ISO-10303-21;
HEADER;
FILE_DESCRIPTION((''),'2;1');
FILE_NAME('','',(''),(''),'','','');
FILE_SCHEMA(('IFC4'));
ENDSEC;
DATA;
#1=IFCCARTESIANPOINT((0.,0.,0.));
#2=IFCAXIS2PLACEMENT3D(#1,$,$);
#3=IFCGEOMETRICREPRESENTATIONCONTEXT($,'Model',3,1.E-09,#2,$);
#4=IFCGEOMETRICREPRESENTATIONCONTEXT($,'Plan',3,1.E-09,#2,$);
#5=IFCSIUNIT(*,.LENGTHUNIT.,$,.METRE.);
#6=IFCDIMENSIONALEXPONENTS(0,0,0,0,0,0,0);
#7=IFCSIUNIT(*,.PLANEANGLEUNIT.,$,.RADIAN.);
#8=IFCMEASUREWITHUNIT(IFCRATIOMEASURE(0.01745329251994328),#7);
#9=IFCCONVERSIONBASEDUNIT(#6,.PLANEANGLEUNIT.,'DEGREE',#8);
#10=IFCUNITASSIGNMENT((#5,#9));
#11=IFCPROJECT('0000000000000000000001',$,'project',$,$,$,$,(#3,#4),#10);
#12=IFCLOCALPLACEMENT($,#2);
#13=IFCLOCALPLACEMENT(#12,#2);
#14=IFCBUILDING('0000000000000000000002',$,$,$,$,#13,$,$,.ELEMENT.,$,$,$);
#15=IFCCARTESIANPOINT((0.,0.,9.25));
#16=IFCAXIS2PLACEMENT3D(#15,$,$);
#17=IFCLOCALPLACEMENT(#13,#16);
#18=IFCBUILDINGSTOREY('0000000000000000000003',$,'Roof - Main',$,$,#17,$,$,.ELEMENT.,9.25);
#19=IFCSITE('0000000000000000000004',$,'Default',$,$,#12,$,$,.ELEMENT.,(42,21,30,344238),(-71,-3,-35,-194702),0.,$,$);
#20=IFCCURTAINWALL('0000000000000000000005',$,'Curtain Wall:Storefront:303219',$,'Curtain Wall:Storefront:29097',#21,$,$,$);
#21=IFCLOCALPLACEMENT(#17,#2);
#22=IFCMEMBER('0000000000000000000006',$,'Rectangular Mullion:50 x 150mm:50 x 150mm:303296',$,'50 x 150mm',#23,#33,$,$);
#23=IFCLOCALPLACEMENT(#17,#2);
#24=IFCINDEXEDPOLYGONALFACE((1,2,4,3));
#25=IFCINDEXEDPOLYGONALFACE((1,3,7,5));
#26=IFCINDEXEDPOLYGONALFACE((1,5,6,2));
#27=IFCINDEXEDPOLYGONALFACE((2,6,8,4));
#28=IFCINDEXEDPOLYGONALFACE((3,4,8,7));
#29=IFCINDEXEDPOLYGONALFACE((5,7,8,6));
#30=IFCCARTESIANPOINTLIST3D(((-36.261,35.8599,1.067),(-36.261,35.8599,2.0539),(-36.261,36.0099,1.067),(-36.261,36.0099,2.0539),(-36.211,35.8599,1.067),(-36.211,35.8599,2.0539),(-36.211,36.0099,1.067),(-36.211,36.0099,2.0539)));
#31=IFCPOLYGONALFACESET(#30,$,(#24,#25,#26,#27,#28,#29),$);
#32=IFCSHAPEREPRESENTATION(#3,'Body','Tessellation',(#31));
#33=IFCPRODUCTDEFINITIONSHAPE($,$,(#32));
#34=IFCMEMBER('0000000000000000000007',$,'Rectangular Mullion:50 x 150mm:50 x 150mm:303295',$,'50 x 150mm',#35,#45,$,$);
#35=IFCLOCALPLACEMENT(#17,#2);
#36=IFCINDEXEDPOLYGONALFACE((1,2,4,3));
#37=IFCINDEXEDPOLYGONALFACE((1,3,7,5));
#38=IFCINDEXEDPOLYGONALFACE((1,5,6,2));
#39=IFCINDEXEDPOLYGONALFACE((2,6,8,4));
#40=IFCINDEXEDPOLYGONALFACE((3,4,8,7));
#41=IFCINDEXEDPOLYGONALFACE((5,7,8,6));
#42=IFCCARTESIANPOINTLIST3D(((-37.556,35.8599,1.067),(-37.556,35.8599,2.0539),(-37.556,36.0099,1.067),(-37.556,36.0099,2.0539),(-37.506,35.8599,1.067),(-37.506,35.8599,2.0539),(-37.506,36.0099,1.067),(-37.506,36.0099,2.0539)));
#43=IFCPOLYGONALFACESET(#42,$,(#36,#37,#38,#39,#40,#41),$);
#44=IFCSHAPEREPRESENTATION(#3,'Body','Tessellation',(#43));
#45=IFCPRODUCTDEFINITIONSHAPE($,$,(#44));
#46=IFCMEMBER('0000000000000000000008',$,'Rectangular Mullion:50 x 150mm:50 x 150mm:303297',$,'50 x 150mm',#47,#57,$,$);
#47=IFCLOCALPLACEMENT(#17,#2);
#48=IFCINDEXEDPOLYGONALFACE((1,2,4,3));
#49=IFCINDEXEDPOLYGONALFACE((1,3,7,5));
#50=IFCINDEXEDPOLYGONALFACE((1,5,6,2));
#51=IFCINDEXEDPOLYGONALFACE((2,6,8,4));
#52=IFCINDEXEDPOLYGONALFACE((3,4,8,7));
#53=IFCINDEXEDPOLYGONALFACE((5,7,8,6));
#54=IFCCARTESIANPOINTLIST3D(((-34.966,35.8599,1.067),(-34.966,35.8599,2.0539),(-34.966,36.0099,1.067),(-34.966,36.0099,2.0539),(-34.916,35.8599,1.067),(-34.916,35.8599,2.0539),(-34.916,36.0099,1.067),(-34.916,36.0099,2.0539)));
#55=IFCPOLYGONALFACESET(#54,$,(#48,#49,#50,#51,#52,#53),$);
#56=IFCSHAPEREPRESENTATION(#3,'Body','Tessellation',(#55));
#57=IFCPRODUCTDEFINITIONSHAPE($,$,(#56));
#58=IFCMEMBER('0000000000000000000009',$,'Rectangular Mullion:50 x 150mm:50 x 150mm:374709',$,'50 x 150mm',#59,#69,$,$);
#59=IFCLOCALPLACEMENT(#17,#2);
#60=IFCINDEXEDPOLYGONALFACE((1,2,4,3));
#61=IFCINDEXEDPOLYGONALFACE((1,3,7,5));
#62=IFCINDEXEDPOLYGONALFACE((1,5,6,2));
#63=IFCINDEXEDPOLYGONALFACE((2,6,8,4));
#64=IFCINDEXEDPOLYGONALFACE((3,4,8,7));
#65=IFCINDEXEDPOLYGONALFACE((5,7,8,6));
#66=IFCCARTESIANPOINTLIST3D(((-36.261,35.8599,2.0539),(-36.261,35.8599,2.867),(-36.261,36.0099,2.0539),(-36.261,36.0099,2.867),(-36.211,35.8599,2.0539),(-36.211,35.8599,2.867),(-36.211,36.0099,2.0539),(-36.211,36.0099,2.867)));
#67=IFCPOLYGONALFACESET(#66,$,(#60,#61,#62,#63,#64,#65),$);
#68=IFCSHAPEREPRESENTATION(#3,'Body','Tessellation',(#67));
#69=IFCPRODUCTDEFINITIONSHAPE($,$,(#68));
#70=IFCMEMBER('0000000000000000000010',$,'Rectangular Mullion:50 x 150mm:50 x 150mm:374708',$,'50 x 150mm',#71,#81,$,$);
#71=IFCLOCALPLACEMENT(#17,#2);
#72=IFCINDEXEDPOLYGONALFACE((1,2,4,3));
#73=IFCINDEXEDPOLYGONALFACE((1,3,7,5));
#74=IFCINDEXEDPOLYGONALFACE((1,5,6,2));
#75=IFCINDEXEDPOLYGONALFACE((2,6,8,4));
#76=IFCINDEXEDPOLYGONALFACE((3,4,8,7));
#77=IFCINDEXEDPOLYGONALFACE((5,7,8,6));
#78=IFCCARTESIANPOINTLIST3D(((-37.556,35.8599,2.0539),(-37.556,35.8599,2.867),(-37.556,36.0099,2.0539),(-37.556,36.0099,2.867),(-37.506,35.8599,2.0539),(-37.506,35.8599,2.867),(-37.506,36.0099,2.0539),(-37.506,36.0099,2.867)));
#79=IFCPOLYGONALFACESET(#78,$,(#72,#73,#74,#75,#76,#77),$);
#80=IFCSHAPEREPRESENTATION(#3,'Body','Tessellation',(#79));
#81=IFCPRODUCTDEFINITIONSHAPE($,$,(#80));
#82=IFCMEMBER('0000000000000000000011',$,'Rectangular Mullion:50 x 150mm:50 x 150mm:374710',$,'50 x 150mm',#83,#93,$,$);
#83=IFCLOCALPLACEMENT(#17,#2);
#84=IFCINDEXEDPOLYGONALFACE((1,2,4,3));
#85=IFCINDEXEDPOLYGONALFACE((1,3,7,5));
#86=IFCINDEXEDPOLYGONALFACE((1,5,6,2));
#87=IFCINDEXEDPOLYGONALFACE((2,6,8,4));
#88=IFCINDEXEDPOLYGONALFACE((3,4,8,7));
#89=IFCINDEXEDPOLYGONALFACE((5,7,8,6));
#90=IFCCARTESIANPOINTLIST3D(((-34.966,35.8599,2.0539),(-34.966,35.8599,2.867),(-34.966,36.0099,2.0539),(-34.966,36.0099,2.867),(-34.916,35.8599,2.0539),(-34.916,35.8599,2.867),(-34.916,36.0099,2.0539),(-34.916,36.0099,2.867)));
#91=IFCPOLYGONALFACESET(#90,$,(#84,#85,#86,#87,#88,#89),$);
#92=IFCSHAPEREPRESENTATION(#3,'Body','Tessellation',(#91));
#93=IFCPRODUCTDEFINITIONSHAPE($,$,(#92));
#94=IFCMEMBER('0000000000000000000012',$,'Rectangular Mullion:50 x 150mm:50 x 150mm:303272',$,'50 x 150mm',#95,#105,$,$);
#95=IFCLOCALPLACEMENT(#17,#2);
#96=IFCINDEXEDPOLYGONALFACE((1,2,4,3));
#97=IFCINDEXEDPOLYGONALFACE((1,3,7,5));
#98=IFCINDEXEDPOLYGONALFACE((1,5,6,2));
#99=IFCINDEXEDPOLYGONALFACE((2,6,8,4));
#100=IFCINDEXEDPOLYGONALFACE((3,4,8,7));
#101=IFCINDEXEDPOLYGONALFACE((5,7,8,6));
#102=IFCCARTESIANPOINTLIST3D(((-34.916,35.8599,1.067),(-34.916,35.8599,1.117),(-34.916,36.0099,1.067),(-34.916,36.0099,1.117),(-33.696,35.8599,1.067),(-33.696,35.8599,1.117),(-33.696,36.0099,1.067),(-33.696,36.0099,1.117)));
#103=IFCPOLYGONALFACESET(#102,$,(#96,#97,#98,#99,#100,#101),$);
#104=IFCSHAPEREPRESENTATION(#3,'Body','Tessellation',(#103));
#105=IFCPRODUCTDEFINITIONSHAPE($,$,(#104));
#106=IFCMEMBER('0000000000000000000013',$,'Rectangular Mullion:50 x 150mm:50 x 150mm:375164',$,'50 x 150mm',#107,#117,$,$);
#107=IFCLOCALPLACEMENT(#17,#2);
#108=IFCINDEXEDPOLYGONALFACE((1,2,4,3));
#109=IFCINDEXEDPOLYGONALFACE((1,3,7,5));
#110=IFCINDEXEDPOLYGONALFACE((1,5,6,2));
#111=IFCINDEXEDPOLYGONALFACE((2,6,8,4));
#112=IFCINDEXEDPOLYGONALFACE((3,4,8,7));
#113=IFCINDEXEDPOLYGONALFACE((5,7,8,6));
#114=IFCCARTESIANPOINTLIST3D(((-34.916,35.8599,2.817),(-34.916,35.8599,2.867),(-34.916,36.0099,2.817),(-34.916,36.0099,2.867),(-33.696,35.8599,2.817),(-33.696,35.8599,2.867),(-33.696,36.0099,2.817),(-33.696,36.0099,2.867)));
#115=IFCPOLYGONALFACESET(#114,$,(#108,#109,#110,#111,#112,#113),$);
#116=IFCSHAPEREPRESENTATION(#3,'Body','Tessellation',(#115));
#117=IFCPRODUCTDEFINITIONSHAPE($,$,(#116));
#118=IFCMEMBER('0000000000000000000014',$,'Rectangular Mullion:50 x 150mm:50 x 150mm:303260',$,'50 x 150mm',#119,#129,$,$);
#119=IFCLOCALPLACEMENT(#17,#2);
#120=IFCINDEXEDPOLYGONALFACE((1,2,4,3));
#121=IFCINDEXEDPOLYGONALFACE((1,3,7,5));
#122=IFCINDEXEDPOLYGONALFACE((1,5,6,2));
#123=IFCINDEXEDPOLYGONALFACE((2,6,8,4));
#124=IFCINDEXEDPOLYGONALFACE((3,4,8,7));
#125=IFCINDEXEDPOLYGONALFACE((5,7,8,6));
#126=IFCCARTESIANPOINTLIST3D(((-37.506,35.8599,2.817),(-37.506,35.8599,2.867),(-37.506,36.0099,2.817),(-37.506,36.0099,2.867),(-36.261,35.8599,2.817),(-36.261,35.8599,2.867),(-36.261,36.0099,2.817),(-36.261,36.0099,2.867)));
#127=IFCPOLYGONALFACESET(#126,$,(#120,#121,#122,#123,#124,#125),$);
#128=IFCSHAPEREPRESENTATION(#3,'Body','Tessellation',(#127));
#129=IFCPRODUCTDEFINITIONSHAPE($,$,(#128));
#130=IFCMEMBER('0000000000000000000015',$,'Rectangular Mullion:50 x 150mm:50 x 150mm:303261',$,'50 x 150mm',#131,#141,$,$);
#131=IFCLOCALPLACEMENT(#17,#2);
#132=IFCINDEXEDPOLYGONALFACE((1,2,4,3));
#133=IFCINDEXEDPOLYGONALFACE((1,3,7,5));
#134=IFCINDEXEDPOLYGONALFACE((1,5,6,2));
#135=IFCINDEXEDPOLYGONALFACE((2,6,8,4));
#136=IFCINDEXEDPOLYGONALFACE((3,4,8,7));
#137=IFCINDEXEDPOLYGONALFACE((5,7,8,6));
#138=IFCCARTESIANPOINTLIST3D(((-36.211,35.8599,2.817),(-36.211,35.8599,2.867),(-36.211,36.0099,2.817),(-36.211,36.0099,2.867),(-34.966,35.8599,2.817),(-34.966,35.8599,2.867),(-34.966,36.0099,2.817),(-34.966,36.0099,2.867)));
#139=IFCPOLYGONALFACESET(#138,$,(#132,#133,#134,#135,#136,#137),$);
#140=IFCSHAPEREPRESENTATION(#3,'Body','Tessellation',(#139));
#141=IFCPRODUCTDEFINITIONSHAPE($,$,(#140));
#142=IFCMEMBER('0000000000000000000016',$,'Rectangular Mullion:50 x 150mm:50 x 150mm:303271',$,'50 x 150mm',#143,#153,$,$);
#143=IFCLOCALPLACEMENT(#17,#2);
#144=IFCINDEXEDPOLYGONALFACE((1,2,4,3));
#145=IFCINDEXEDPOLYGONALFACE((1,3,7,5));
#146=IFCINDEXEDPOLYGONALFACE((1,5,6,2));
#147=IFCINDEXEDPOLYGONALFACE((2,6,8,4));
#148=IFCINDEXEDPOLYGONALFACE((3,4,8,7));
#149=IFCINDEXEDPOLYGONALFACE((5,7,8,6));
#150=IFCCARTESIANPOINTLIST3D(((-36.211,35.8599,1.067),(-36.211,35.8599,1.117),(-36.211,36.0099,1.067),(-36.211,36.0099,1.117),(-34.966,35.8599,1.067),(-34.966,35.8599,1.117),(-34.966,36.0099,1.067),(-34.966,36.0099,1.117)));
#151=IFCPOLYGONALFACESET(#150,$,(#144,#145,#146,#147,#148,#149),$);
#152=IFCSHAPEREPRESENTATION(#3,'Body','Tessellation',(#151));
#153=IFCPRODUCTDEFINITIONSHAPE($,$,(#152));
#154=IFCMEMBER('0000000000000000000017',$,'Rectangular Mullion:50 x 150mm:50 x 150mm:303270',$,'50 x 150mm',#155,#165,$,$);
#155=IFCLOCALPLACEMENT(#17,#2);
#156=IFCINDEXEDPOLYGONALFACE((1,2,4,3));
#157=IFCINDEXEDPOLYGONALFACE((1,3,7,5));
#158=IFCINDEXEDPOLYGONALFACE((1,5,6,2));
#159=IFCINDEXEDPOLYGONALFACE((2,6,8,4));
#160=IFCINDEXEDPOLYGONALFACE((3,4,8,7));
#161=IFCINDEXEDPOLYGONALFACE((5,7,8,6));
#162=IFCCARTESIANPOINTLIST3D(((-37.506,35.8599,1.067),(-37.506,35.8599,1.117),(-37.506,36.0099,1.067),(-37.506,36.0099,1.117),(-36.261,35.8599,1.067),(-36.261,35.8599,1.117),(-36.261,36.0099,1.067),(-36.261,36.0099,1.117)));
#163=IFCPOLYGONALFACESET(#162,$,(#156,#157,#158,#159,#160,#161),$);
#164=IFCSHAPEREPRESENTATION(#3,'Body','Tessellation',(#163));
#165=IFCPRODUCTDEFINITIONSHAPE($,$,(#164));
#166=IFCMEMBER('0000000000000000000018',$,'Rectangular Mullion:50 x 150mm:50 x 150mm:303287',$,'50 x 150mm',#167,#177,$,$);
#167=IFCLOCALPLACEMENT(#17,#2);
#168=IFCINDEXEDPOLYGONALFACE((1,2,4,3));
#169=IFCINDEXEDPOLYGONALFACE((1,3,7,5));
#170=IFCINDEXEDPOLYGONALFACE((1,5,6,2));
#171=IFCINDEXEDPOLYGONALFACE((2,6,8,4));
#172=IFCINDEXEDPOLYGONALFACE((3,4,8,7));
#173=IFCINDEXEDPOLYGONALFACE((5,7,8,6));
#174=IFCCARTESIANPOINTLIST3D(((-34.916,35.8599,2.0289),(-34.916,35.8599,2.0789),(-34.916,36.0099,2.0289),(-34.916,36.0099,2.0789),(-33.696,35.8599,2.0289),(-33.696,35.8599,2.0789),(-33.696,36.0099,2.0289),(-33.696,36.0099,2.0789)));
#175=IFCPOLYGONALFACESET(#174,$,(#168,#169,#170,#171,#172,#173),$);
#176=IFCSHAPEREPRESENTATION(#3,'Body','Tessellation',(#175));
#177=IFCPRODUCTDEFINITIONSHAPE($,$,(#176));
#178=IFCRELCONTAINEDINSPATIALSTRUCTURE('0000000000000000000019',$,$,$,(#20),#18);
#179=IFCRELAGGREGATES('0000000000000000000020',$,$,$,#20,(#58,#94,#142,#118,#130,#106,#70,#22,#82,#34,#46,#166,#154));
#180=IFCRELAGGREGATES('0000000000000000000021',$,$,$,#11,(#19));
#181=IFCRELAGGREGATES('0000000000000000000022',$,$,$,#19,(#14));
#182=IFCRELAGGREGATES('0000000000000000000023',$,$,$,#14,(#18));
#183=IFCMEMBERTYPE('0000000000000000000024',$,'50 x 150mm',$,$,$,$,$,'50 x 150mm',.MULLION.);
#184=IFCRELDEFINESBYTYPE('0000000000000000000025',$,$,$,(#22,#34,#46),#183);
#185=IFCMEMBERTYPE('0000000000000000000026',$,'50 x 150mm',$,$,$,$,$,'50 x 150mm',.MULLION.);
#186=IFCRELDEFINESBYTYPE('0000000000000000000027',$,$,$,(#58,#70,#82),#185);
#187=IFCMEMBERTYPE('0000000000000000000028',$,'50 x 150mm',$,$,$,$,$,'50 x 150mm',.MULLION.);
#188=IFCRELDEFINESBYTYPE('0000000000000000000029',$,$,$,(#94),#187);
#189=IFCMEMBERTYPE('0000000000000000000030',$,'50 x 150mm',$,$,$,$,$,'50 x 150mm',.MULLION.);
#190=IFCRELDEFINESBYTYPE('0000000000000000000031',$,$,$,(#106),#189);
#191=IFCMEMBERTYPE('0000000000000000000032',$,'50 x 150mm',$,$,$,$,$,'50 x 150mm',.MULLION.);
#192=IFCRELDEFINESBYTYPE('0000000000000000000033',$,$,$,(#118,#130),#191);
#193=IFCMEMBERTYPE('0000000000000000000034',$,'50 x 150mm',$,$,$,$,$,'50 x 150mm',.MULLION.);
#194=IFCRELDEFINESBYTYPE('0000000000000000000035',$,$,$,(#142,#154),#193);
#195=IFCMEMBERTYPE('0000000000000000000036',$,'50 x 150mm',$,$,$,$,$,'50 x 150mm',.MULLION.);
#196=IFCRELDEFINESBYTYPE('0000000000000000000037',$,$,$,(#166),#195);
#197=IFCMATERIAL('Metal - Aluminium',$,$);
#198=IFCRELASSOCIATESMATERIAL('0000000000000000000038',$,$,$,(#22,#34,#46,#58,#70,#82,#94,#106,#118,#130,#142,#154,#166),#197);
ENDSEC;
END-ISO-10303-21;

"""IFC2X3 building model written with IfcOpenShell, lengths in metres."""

from ifc_helpers import new_model, entity, si_unit, converted_unit, frame, origin, origin_2d_with_axis, place, context, project, spatial, rectangle, extrude, source, transform, mapped, material, type_object, type_shapes, element, aggregate, save


model = new_model("IFC2X3")

# Units and contexts
model_context = context("Model", 3, precision=1e-09, world=origin())
plan_context = context("Plan", 3, precision=1e-09, world=origin())
ifc_project = project(units=[si_unit("LENGTHUNIT", "METRE"), converted_unit("PLANEANGLEUNIT", "DEGREE", entity("IfcRatioMeasure", 0.01745329251994328), si_unit("PLANEANGLEUNIT", "RADIAN"), dimensions=[0, 0, 0, 0, 0, 0, 0])], contexts=[model_context, plan_context])

# Site, building, storey
site_placement = place(None, origin())
site = spatial("IfcSite", under=ifc_project, at=site_placement, Name="Default", CompositionType="ELEMENT", RefLatitude=(42, 21, 30, 344238), RefLongitude=(-71, -3, -35, -194702), RefElevation=0.0)
building_placement = place(site_placement, origin())
building = spatial("IfcBuilding", under=site, at=building_placement, CompositionType="ELEMENT")
storey_placement = place(building_placement, frame((0.0, 0.0, 9.25)))
storey = spatial("IfcBuildingStorey", under=building, at=storey_placement, Name="Roof - Main", CompositionType="ELEMENT", Elevation=9.25)

# Curtain wall, members
curtain_wall_placement = place(storey_placement, origin())
curtain_wall = element("IfcCurtainWall", 1, at=curtain_wall_placement, inside=storey, Name="Curtain Wall:Storefront:303219", ObjectType="Curtain Wall:Storefront:29097")
ifc_material_1 = material(Name="Metal - Aluminium")
member_type_1 = type_object("IfcMemberType", Name="50 x 150mm", ElementType="50 x 150mm", PredefinedType="MULLION")
shared_shape_1 = source(origin(), model_context, "Body", "SweptSolid", [
    extrude(rectangle(XDim=0.05, YDim=0.15, at=origin_2d_with_axis()), frame((0.0, 0.0, -0.9869), z_axis=(0.0, 0.0, 1.0), x_axis=(-1.0, 0.0, 0.0)), (0.0, 0.0, 1.0), 0.9869),
])
type_shapes(member_type_1, [shared_shape_1])
member_1_placement = place(storey_placement, frame((-36.236, 35.9349, 1.067), z_axis=(0.0, 0.0, -1.0), x_axis=(1.0, 0.0, 0.0)))
member_1 = element("IfcMember", 2, at=member_1_placement, type_object=member_type_1, material=ifc_material_1, Name="Rectangular Mullion:50 x 150mm:50 x 150mm:303296", ObjectType="50 x 150mm", context=model_context, shape_type="MappedRepresentation", body=[
    mapped(shared_shape_1, transform((0.0, 0.0, 0.0), scale=1.0)),
])
member_2_placement = place(storey_placement, frame((-37.531, 35.9349, 1.067), z_axis=(0.0, 0.0, -1.0), x_axis=(1.0, 0.0, 0.0)))
member_2 = element("IfcMember", 3, at=member_2_placement, type_object=member_type_1, material=ifc_material_1, Name="Rectangular Mullion:50 x 150mm:50 x 150mm:303295", ObjectType="50 x 150mm", context=model_context, shape_type="MappedRepresentation", body=[
    mapped(shared_shape_1, transform((0.0, 0.0, 0.0), scale=1.0)),
])
member_3_placement = place(storey_placement, frame((-34.941, 35.9349, 1.067), z_axis=(0.0, 0.0, -1.0), x_axis=(1.0, 0.0, 0.0)))
member_3 = element("IfcMember", 4, at=member_3_placement, type_object=member_type_1, material=ifc_material_1, Name="Rectangular Mullion:50 x 150mm:50 x 150mm:303297", ObjectType="50 x 150mm", context=model_context, shape_type="MappedRepresentation", body=[
    mapped(shared_shape_1, transform((0.0, 0.0, 0.0), scale=1.0)),
])
member_type_2 = type_object("IfcMemberType", Name="50 x 150mm", ElementType="50 x 150mm", PredefinedType="MULLION")
shared_shape_2 = source(origin(), model_context, "Body", "SweptSolid", [
    extrude(rectangle(XDim=0.05, YDim=0.15, at=origin_2d_with_axis()), frame((0.0, 0.0, -0.8131), z_axis=(0.0, 0.0, 1.0), x_axis=(-1.0, 0.0, 0.0)), (0.0, 0.0, 1.0), 0.8131),
])
type_shapes(member_type_2, [shared_shape_2])
member_4_placement = place(storey_placement, frame((-36.236, 35.9349, 2.0539), z_axis=(0.0, 0.0, -1.0), x_axis=(1.0, 0.0, 0.0)))
member_4 = element("IfcMember", 5, at=member_4_placement, type_object=member_type_2, material=ifc_material_1, Name="Rectangular Mullion:50 x 150mm:50 x 150mm:374709", ObjectType="50 x 150mm", context=model_context, shape_type="MappedRepresentation", body=[
    mapped(shared_shape_2, transform((0.0, 0.0, 0.0), scale=1.0)),
])
member_5_placement = place(storey_placement, frame((-37.531, 35.9349, 2.0539), z_axis=(0.0, 0.0, -1.0), x_axis=(1.0, 0.0, 0.0)))
member_5 = element("IfcMember", 6, at=member_5_placement, type_object=member_type_2, material=ifc_material_1, Name="Rectangular Mullion:50 x 150mm:50 x 150mm:374708", ObjectType="50 x 150mm", context=model_context, shape_type="MappedRepresentation", body=[
    mapped(shared_shape_2, transform((0.0, 0.0, 0.0), scale=1.0)),
])
member_6_placement = place(storey_placement, frame((-34.941, 35.9349, 2.0539), z_axis=(0.0, 0.0, -1.0), x_axis=(1.0, 0.0, 0.0)))
member_6 = element("IfcMember", 7, at=member_6_placement, type_object=member_type_2, material=ifc_material_1, Name="Rectangular Mullion:50 x 150mm:50 x 150mm:374710", ObjectType="50 x 150mm", context=model_context, shape_type="MappedRepresentation", body=[
    mapped(shared_shape_2, transform((0.0, 0.0, 0.0), scale=1.0)),
])
member_type_3 = type_object("IfcMemberType", Name="50 x 150mm", ElementType="50 x 150mm", PredefinedType="MULLION")
shared_shape_3 = source(origin(), model_context, "Body", "SweptSolid", [
    extrude(rectangle(XDim=0.05, YDim=0.15, at=origin_2d_with_axis()), frame((-0.025, 0.0, -1.22), z_axis=(0.0, 0.0, 1.0), x_axis=(-1.0, 0.0, 0.0)), (0.0, 0.0, 1.0), 1.22),
])
type_shapes(member_type_3, [shared_shape_3])
member_7_placement = place(storey_placement, frame((-34.916, 35.9349, 1.067), z_axis=(-1.0, 0.0, 0.0), x_axis=(0.0, 0.0, -1.0)))
member_7 = element("IfcMember", 8, at=member_7_placement, type_object=member_type_3, material=ifc_material_1, Name="Rectangular Mullion:50 x 150mm:50 x 150mm:303272", ObjectType="50 x 150mm", context=model_context, shape_type="MappedRepresentation", body=[
    mapped(shared_shape_3, transform((0.0, 0.0, 0.0), scale=1.0)),
])
member_type_4 = type_object("IfcMemberType", Name="50 x 150mm", ElementType="50 x 150mm", PredefinedType="MULLION")
type_shapes(member_type_4, [shared_shape_3])
member_8_placement = place(storey_placement, frame((-33.696, 35.9349, 2.867), z_axis=(1.0, 0.0, 0.0), x_axis=(0.0, 0.0, 1.0)))
member_8 = element("IfcMember", 9, at=member_8_placement, type_object=member_type_4, material=ifc_material_1, Name="Rectangular Mullion:50 x 150mm:50 x 150mm:375164", ObjectType="50 x 150mm", context=model_context, shape_type="MappedRepresentation", body=[
    mapped(shared_shape_3, transform((0.0, 0.0, 0.0), scale=1.0)),
])
member_type_5 = type_object("IfcMemberType", Name="50 x 150mm", ElementType="50 x 150mm", PredefinedType="MULLION")
shared_shape_4 = source(origin(), model_context, "Body", "SweptSolid", [
    extrude(rectangle(XDim=0.05, YDim=0.15, at=origin_2d_with_axis()), frame((-0.025, 0.0, -1.245), z_axis=(0.0, 0.0, 1.0), x_axis=(-1.0, 0.0, 0.0)), (0.0, 0.0, 1.0), 1.245),
])
type_shapes(member_type_5, [shared_shape_4])
member_9_placement = place(storey_placement, frame((-36.261, 35.9349, 2.867), z_axis=(1.0, 0.0, 0.0), x_axis=(0.0, 0.0, 1.0)))
member_9 = element("IfcMember", 10, at=member_9_placement, type_object=member_type_5, material=ifc_material_1, Name="Rectangular Mullion:50 x 150mm:50 x 150mm:303260", ObjectType="50 x 150mm", context=model_context, shape_type="MappedRepresentation", body=[
    mapped(shared_shape_4, transform((0.0, 0.0, 0.0), scale=1.0)),
])
member_10_placement = place(storey_placement, frame((-34.966, 35.9349, 2.867), z_axis=(1.0, 0.0, 0.0), x_axis=(0.0, 0.0, 1.0)))
member_10 = element("IfcMember", 11, at=member_10_placement, type_object=member_type_5, material=ifc_material_1, Name="Rectangular Mullion:50 x 150mm:50 x 150mm:303261", ObjectType="50 x 150mm", context=model_context, shape_type="MappedRepresentation", body=[
    mapped(shared_shape_4, transform((0.0, 0.0, 0.0), scale=1.0)),
])
member_type_6 = type_object("IfcMemberType", Name="50 x 150mm", ElementType="50 x 150mm", PredefinedType="MULLION")
shared_shape_5 = source(origin(), model_context, "Body", "SweptSolid", [
    extrude(rectangle(XDim=0.05, YDim=0.15, at=origin_2d_with_axis()), frame((-0.025, 0.0, -1.245), z_axis=(0.0, 0.0, 1.0), x_axis=(-1.0, 0.0, 0.0)), (0.0, 0.0, 1.0), 1.245),
])
type_shapes(member_type_6, [shared_shape_5])
member_11_placement = place(storey_placement, frame((-36.211, 35.9349, 1.067), z_axis=(-1.0, 0.0, 0.0), x_axis=(0.0, 0.0, -1.0)))
member_11 = element("IfcMember", 12, at=member_11_placement, type_object=member_type_6, material=ifc_material_1, Name="Rectangular Mullion:50 x 150mm:50 x 150mm:303271", ObjectType="50 x 150mm", context=model_context, shape_type="MappedRepresentation", body=[
    mapped(shared_shape_5, transform((0.0, 0.0, 0.0), scale=1.0)),
])
member_12_placement = place(storey_placement, frame((-37.506, 35.9349, 1.067), z_axis=(-1.0, 0.0, 0.0), x_axis=(0.0, 0.0, -1.0)))
member_12 = element("IfcMember", 13, at=member_12_placement, type_object=member_type_6, material=ifc_material_1, Name="Rectangular Mullion:50 x 150mm:50 x 150mm:303270", ObjectType="50 x 150mm", context=model_context, shape_type="MappedRepresentation", body=[
    mapped(shared_shape_5, transform((0.0, 0.0, 0.0), scale=1.0)),
])
member_type_7 = type_object("IfcMemberType", Name="50 x 150mm", ElementType="50 x 150mm", PredefinedType="MULLION")
shared_shape_6 = source(origin(), model_context, "Body", "SweptSolid", [
    extrude(rectangle(XDim=0.05, YDim=0.15, at=origin_2d_with_axis()), frame((0.0, 0.0, -1.22), z_axis=(0.0, 0.0, 1.0), x_axis=(-1.0, 0.0, 0.0)), (0.0, 0.0, 1.0), 1.22),
])
type_shapes(member_type_7, [shared_shape_6])
member_13_placement = place(storey_placement, frame((-33.696, 35.9349, 2.0539), z_axis=(1.0, 0.0, 0.0), x_axis=(0.0, 0.0, 1.0)))
member_13 = element("IfcMember", 14, at=member_13_placement, type_object=member_type_7, material=ifc_material_1, Name="Rectangular Mullion:50 x 150mm:50 x 150mm:303287", ObjectType="50 x 150mm", context=model_context, shape_type="MappedRepresentation", body=[
    mapped(shared_shape_6, transform((0.0, 0.0, 0.0), scale=1.0)),
])
aggregate(curtain_wall, [member_4, member_7, member_11, member_9, member_10, member_8, member_5, member_1, member_6, member_2, member_3, member_13, member_12])

save(model, "model.ifc")
